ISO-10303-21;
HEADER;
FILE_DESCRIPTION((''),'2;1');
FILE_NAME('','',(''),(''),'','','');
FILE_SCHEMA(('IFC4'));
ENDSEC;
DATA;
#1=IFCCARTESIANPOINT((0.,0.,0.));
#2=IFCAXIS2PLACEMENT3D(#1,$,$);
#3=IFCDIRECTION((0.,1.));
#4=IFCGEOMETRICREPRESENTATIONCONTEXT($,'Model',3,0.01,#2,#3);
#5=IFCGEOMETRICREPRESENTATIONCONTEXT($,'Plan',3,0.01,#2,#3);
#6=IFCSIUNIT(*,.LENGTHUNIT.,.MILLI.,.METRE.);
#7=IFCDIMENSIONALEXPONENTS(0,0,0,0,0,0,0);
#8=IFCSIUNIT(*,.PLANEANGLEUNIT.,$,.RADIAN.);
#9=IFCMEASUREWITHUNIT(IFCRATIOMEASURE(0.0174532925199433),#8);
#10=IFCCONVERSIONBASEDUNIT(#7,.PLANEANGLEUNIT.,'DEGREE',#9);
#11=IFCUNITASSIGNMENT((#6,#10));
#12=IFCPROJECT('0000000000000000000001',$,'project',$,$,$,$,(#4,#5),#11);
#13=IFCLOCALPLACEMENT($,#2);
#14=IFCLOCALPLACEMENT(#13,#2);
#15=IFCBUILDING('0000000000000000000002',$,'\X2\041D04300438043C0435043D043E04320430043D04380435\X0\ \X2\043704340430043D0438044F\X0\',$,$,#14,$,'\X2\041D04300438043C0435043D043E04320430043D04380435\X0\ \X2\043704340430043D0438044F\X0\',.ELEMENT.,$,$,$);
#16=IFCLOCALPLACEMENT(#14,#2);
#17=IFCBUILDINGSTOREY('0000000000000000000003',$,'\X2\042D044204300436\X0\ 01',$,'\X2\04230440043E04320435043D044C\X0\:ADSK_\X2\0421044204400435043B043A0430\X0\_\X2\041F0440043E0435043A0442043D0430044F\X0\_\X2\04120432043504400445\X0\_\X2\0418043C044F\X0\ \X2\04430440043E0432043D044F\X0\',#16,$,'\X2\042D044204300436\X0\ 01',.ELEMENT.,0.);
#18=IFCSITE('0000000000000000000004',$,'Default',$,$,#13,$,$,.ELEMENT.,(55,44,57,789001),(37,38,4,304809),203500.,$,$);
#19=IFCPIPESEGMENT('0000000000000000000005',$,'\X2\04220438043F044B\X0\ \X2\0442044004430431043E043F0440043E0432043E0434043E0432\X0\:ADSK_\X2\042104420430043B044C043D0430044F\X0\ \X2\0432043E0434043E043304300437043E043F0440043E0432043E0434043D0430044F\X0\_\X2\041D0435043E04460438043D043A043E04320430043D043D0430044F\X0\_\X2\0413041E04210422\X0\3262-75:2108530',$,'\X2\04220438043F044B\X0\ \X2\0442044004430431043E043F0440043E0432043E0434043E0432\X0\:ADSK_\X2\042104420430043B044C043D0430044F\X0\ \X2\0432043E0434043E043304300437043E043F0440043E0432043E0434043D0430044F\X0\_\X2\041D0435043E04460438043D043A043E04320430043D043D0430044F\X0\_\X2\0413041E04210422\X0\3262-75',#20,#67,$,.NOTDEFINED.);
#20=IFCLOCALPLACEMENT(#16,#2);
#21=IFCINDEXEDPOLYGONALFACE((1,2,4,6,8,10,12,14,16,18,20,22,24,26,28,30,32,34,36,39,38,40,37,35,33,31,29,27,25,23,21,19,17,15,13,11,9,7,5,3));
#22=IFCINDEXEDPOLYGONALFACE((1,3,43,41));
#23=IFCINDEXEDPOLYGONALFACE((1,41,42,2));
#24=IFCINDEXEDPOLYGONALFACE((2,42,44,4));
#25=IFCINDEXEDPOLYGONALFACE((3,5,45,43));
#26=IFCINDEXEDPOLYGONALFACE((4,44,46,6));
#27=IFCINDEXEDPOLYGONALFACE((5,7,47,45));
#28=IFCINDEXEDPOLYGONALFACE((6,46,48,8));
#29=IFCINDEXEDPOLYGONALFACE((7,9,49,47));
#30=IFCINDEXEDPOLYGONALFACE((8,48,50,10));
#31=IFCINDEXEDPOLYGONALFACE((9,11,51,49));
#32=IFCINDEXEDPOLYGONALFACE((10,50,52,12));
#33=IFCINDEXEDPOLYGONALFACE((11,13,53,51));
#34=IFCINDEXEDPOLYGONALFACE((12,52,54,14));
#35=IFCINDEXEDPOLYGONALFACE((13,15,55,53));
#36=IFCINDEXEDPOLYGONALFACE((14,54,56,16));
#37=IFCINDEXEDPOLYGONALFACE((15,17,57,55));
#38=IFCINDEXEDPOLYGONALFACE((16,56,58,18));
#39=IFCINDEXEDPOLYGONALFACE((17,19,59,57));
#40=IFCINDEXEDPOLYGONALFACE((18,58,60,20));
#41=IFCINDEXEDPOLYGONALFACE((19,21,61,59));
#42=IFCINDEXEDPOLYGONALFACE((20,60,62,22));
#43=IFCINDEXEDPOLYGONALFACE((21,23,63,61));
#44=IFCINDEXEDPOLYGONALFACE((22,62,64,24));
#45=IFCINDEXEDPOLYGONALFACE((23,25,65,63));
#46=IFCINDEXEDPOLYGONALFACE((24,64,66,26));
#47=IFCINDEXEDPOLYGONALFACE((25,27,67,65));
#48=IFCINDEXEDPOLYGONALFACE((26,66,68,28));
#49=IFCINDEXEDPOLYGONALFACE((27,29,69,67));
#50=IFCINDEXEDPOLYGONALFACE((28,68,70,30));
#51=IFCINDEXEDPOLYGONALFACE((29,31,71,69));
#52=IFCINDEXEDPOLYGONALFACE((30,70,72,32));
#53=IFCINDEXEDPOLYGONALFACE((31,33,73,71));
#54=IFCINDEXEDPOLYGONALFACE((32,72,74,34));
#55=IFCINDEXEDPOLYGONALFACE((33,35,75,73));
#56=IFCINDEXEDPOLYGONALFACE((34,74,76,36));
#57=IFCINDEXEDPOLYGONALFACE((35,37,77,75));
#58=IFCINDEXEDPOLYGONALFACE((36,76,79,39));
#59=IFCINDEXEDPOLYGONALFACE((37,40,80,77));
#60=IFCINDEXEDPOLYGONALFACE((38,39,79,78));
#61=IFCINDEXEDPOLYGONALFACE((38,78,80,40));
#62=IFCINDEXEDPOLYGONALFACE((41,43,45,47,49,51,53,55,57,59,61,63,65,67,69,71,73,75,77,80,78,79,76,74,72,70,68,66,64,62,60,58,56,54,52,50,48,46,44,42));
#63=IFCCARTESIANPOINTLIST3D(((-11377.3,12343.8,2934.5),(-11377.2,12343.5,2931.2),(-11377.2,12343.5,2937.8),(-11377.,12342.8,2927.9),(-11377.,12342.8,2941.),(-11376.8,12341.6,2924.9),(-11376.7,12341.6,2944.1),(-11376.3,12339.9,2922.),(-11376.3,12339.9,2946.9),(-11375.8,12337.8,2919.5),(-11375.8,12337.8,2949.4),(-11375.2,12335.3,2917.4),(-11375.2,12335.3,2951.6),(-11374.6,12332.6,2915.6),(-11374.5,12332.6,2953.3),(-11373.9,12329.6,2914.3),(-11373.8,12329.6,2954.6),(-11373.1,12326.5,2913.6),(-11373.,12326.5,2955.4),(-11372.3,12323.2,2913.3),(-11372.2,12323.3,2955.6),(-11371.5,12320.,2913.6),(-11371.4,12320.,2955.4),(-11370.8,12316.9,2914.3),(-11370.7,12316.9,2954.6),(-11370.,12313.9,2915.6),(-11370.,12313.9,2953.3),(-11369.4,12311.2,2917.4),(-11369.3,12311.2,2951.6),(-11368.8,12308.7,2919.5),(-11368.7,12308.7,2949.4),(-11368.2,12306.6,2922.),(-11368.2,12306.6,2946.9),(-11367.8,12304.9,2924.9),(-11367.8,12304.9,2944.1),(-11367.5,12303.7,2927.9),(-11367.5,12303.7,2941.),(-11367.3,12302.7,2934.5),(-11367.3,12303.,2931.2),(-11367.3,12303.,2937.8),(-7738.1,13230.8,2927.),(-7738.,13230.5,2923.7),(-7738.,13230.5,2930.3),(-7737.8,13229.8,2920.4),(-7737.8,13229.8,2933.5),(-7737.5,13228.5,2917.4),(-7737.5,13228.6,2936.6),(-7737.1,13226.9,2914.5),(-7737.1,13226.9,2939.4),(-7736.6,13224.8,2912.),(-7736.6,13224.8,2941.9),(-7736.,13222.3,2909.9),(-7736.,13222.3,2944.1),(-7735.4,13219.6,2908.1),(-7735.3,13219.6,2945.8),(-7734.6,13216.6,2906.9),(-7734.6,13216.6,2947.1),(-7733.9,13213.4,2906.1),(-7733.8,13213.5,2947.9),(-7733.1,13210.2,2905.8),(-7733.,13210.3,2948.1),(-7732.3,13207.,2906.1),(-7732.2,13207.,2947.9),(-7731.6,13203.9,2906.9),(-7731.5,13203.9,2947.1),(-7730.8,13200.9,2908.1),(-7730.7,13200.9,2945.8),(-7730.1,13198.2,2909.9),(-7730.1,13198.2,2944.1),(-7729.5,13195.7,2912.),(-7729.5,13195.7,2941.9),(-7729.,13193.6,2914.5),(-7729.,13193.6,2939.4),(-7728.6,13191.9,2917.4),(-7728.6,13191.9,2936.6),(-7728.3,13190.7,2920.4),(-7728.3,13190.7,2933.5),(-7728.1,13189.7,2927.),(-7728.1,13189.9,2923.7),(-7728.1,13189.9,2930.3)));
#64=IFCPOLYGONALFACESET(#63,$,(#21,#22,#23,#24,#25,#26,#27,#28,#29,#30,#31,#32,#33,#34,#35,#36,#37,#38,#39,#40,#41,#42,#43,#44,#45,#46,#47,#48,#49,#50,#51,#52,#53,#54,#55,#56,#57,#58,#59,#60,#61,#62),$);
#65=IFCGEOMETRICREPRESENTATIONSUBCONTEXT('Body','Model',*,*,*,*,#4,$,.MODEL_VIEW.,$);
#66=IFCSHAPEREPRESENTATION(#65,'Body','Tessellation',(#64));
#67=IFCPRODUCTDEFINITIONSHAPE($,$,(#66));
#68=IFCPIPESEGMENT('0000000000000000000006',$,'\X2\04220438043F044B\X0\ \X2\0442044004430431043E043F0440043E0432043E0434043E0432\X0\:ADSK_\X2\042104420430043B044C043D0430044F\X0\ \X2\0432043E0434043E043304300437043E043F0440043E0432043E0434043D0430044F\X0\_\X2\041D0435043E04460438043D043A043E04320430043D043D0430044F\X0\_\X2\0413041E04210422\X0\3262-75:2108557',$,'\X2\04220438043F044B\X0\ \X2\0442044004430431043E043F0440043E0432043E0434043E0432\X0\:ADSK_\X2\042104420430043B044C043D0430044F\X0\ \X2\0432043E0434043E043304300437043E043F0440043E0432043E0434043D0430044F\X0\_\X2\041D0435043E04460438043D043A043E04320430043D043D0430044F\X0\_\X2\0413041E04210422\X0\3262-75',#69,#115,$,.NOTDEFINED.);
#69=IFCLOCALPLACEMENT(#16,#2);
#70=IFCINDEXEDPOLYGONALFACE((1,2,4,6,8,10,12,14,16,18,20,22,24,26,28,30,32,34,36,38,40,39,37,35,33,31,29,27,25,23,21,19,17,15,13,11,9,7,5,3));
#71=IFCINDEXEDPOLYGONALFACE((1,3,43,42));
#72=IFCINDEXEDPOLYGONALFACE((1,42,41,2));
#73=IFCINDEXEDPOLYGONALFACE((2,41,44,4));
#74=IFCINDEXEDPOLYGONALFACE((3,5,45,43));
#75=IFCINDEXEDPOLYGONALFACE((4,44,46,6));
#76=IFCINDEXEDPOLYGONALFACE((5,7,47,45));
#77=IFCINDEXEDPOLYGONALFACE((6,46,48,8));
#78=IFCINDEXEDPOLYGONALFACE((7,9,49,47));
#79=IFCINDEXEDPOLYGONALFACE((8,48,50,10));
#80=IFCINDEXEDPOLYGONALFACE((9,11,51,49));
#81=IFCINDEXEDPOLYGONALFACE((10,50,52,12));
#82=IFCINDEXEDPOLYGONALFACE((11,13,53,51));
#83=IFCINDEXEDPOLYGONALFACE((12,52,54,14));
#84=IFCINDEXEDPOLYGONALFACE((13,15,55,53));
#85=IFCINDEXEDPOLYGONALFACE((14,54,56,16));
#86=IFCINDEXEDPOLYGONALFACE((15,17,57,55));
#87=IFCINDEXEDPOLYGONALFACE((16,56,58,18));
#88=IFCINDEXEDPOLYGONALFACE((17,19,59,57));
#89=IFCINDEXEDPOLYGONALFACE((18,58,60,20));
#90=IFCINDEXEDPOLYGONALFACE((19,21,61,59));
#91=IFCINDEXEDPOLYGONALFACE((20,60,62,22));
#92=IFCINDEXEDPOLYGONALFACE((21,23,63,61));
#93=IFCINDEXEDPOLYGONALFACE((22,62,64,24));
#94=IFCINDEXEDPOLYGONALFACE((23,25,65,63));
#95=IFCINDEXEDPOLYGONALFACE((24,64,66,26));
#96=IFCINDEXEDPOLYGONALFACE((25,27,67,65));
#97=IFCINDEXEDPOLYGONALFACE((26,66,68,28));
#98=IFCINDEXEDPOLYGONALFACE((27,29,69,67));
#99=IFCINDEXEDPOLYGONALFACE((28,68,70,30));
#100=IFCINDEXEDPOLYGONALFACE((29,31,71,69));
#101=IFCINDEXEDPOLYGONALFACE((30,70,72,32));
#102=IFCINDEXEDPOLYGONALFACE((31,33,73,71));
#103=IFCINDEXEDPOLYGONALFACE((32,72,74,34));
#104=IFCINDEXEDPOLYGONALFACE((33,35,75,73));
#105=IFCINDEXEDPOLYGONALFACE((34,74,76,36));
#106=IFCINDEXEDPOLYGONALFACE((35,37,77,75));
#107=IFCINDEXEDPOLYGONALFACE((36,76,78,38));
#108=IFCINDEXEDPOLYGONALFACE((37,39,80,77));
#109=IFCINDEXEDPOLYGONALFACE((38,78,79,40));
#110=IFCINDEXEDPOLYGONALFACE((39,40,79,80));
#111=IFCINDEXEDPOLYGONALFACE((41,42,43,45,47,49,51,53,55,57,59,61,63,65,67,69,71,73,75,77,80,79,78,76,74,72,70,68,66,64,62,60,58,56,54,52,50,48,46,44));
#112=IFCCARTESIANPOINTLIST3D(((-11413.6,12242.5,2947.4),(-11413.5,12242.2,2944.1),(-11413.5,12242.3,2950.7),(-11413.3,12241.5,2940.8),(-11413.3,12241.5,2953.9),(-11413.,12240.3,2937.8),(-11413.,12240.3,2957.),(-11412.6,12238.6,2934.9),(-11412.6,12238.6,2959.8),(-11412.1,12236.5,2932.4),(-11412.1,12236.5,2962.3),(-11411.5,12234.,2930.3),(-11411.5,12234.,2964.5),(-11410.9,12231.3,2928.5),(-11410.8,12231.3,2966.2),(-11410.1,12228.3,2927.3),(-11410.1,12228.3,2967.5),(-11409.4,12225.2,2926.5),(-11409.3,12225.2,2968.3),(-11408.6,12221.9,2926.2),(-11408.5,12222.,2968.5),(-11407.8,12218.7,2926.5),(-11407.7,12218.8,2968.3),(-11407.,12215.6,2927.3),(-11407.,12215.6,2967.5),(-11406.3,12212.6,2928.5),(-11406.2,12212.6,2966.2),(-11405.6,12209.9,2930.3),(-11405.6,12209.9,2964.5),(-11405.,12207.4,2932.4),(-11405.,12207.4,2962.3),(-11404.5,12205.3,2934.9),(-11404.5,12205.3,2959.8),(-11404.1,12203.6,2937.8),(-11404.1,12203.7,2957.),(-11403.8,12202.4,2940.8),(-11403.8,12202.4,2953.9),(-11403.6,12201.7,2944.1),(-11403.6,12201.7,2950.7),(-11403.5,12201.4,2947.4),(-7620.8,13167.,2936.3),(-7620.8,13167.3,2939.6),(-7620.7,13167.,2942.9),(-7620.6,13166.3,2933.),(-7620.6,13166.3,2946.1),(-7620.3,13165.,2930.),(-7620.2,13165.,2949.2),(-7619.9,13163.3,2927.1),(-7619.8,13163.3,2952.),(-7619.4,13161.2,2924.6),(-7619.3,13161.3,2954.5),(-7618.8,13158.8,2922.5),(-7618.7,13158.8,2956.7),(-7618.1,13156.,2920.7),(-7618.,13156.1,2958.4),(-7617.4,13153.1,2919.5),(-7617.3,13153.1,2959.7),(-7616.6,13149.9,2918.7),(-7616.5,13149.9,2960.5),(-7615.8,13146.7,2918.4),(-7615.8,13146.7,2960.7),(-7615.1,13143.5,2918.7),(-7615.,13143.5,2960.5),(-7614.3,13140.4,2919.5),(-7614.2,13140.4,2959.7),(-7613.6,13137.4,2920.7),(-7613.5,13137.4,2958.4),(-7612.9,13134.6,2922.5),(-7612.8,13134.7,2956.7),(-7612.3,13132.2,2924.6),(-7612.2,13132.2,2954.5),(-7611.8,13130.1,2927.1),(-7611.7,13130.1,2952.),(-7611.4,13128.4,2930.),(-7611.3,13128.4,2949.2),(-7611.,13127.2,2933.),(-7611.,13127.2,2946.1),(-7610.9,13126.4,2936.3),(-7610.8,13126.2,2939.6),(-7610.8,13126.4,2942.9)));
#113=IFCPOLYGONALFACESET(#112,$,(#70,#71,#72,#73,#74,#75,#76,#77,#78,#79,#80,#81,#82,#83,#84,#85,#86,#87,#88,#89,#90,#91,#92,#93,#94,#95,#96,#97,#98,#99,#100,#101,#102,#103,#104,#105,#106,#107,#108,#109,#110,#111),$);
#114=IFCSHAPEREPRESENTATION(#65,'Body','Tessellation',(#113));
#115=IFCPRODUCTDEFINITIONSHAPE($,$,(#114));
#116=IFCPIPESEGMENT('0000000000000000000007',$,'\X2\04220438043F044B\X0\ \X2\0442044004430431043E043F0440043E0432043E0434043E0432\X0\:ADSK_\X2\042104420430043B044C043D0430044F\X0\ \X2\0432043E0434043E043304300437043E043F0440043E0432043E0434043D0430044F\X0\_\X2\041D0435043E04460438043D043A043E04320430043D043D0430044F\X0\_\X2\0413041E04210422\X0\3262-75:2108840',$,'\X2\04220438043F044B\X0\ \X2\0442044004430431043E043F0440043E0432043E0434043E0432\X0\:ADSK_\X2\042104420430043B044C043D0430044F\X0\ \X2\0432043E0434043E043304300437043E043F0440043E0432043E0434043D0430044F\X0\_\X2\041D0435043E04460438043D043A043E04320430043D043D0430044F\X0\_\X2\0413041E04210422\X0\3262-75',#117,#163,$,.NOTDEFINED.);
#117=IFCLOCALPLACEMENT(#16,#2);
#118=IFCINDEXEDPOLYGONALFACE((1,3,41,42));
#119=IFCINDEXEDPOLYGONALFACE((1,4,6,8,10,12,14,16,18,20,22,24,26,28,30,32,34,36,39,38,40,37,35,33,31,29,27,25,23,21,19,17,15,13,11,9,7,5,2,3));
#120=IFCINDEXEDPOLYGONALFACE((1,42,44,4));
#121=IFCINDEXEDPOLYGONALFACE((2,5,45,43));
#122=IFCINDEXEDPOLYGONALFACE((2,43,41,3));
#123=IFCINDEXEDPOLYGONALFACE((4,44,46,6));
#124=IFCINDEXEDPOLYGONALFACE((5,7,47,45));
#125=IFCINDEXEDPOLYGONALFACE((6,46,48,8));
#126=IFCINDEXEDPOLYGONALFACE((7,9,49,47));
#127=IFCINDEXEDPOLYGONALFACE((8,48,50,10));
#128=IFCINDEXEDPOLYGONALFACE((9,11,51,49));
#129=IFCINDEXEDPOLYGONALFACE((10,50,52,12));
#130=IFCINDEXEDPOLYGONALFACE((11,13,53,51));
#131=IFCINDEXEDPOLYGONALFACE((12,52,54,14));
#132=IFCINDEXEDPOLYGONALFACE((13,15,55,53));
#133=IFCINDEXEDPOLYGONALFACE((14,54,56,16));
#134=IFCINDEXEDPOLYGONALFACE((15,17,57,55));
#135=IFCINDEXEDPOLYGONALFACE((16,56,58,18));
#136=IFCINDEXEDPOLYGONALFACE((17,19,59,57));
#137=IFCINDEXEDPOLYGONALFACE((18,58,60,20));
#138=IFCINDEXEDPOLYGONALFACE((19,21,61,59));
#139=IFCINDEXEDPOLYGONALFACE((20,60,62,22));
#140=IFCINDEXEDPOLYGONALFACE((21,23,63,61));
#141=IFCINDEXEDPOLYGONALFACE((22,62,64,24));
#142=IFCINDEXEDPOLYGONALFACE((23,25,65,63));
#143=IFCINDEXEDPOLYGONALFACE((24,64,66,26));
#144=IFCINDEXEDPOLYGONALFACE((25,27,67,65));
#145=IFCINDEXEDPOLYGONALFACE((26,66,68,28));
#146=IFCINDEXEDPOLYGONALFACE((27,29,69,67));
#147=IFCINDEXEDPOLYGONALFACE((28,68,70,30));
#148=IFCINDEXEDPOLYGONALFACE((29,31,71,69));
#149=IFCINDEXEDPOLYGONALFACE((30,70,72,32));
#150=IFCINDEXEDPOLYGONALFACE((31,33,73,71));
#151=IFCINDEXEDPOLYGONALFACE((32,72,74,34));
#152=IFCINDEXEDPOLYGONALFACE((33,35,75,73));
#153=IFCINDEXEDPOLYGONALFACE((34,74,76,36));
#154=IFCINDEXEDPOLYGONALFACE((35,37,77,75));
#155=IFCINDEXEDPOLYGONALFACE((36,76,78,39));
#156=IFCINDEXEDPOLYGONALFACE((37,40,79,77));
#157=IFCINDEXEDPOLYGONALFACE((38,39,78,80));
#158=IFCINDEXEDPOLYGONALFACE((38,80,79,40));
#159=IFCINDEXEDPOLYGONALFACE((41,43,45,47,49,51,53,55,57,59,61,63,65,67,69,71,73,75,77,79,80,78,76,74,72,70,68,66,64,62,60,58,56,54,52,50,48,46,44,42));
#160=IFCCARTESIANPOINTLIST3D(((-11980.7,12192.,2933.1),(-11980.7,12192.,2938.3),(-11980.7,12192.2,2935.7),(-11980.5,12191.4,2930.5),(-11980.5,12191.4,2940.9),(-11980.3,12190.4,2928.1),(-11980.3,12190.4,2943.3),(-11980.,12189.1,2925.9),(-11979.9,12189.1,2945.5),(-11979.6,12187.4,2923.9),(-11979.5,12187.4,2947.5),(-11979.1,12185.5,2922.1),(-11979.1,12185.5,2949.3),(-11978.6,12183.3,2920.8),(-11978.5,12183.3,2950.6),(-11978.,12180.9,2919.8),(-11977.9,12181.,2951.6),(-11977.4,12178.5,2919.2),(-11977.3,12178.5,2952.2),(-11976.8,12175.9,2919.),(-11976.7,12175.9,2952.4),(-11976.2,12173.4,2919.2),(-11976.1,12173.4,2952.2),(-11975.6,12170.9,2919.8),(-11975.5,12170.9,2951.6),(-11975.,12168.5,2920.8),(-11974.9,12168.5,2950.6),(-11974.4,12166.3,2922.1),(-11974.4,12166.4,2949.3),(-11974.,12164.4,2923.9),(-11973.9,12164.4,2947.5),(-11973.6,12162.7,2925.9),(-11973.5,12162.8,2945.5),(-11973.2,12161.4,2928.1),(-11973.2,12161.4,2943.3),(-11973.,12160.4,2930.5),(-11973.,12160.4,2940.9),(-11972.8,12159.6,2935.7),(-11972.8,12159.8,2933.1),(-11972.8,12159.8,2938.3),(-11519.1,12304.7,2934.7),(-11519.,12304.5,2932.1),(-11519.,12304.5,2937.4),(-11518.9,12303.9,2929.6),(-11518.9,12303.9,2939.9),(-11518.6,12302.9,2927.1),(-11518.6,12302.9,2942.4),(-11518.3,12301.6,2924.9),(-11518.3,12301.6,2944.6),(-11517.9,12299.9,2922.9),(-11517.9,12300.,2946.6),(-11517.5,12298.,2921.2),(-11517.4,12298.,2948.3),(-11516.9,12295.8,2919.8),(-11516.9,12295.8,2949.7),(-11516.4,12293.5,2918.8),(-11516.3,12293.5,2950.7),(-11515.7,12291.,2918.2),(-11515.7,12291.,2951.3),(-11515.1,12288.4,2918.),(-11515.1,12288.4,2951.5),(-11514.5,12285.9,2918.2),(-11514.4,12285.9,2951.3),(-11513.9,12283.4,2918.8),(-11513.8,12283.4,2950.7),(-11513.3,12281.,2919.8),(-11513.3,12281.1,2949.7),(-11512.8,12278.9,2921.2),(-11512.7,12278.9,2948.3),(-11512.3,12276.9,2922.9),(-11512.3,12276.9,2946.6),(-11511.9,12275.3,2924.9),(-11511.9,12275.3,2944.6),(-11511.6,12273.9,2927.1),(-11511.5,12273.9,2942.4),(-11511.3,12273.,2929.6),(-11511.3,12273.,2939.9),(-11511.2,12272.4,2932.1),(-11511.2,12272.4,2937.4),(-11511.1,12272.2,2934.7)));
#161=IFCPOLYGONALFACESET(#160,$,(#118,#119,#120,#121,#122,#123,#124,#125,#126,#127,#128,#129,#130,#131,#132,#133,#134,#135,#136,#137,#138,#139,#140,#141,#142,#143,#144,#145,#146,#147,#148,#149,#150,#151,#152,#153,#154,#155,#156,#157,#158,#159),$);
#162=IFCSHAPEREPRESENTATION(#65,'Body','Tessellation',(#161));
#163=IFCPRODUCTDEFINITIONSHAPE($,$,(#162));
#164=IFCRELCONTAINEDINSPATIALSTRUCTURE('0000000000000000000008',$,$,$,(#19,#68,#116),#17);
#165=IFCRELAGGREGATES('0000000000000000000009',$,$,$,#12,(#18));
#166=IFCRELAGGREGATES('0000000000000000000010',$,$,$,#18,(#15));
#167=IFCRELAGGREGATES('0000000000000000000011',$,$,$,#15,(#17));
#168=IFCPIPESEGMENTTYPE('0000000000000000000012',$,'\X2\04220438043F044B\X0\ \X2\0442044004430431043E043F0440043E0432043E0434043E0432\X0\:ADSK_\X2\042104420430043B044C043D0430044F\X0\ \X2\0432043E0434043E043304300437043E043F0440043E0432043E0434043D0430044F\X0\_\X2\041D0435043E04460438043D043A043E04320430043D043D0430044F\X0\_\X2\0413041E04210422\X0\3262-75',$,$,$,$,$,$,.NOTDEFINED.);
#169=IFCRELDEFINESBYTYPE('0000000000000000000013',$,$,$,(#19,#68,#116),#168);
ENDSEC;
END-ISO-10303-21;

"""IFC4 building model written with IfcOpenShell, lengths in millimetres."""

from ifc_helpers import new_model, entity, si_unit, converted_unit, direction, frame, origin, place, context, subcontext, project, spatial, indexed_curve, outline, extrude, type_object, element, save


model = new_model("IFC4")

# Units and contexts
model_context = context("Model", 3, precision=0.01, world=origin(), true_north=direction((0.0, 1.0)))
plan_context = context("Plan", 3, precision=0.01, world=origin(), true_north=direction((0.0, 1.0)))
body_context = subcontext(model_context, "Body", "Model", "MODEL_VIEW")
ifc_project = project(units=[si_unit("LENGTHUNIT", "METRE", prefix="MILLI"), converted_unit("PLANEANGLEUNIT", "DEGREE", entity("IfcRatioMeasure", 0.0174532925199433), si_unit("PLANEANGLEUNIT", "RADIAN"), dimensions=[0, 0, 0, 0, 0, 0, 0])], contexts=[model_context, plan_context])

# Site, building, storey
site_placement = place(None, origin())
site = spatial("IfcSite", under=ifc_project, at=site_placement, Name="Default", CompositionType="ELEMENT", RefLatitude=(55, 44, 57, 789001), RefLongitude=(37, 38, 4, 304809), RefElevation=203500.0)
building_placement = place(site_placement, origin())
building = spatial("IfcBuilding", under=site, at=building_placement, Name="Наименование здания", LongName="Наименование здания", CompositionType="ELEMENT")
storey_placement = place(building_placement, origin())
storey = spatial("IfcBuildingStorey", under=building, at=storey_placement, Name="Этаж 01", ObjectType="Уровень:ADSK_Стрелка_Проектная_Вверх_Имя уровня", LongName="Этаж 01", CompositionType="ELEMENT", Elevation=0.0)

# Pipe segments
pipe_segment_type = type_object("IfcPipeSegmentType", Name="Типы трубопроводов:ADSK_Стальная водогазопроводная_Неоцинкованная_ГОСТ3262-75", PredefinedType="NOTDEFINED")
placement = place(storey_placement, origin())
element("IfcPipeSegment", 1, at=placement, inside=storey, type_object=pipe_segment_type, Name="Типы трубопроводов:ADSK_Стальная водогазопроводная_Неоцинкованная_ГОСТ3262-75:2108530", ObjectType="Типы трубопроводов:ADSK_Стальная водогазопроводная_Неоцинкованная_ГОСТ3262-75", PredefinedType="NOTDEFINED", context=body_context, shape_type="SweptSolid", body=[
    extrude(outline(indexed_curve([(21.1, 0.0), (20.9, 3.3), (20.1, 6.5), (18.8, 9.6), (17.1, 12.4), (15.0, 15.0), (12.4, 17.1), (9.6, 18.8), (6.5, 20.1), (3.3, 20.9), (0.0, 21.2), (-3.3, 20.9), (-6.5, 20.1), (-9.6, 18.8), (-12.4, 17.1), (-15.0, 15.0), (-17.1, 12.4), (-18.8, 9.6), (-20.1, 6.5), (-20.9, 3.3), (-21.2, 0.0), (-20.9, -3.3), (-20.1, -6.5), (-18.8, -9.6), (-17.1, -12.4), (-15.0, -15.0), (-12.4, -17.1), (-9.6, -18.8), (-6.5, -20.1), (-3.3, -20.9), (0.0, -21.1), (3.3, -20.9), (6.5, -20.1), (9.6, -18.8), (12.4, -17.1), (15.0, -15.0), (17.1, -12.4), (18.8, -9.6), (20.1, -6.5), (20.9, -3.3), (21.1, 0.0)], self_intersect=False)), frame((-7733.1, 13210.2, 2927.0), z_axis=(-0.971557, -0.236799, 0.002), x_axis=(0.236799, -0.971559, 0.0)), (0.0, 0.0, 1.0), 3745.8),
])
element("IfcPipeSegment", 2, at=placement, inside=storey, type_object=pipe_segment_type, Name="Типы трубопроводов:ADSK_Стальная водогазопроводная_Неоцинкованная_ГОСТ3262-75:2108557", ObjectType="Типы трубопроводов:ADSK_Стальная водогазопроводная_Неоцинкованная_ГОСТ3262-75", PredefinedType="NOTDEFINED", context=body_context, shape_type="SweptSolid", body=[
    extrude(outline(indexed_curve([(21.1, 0.0), (20.9, 3.3), (20.1, 6.5), (18.8, 9.6), (17.1, 12.4), (15.0, 15.0), (12.4, 17.1), (9.6, 18.8), (6.5, 20.1), (3.3, 20.9), (0.0, 21.1), (-3.3, 20.9), (-6.5, 20.1), (-9.6, 18.8), (-12.4, 17.1), (-15.0, 15.0), (-17.1, 12.4), (-18.8, 9.6), (-20.1, 6.5), (-20.9, 3.3), (-21.1, 0.0), (-20.9, -3.3), (-20.1, -6.5), (-18.8, -9.6), (-17.1, -12.4), (-15.0, -15.0), (-12.4, -17.1), (-9.6, -18.8), (-6.5, -20.1), (-3.3, -20.9), (0.0, -21.1), (3.3, -20.9), (6.5, -20.1), (9.6, -18.8), (12.4, -17.1), (15.0, -15.0), (17.1, -12.4), (18.8, -9.6), (20.1, -6.5), (20.9, -3.3), (21.1, 0.0)], self_intersect=False)), frame((-7615.8, 13146.7, 2939.6), z_axis=(-0.971536, -0.236883, 0.002), x_axis=(0.236884, -0.971538, 0.0)), (0.0, 0.0, 1.0), 3903.9),
])
element("IfcPipeSegment", 3, at=placement, inside=storey, type_object=pipe_segment_type, Name="Типы трубопроводов:ADSK_Стальная водогазопроводная_Неоцинкованная_ГОСТ3262-75:2108840", ObjectType="Типы трубопроводов:ADSK_Стальная водогазопроводная_Неоцинкованная_ГОСТ3262-75", PredefinedType="NOTDEFINED", context=body_context, shape_type="SweptSolid", body=[
    extrude(outline(indexed_curve([(16.8, 0.0), (16.5, 2.6), (15.9, 5.2), (14.9, 7.6), (13.6, 9.8), (11.8, 11.8), (9.8, 13.6), (7.6, 14.9), (5.2, 15.9), (2.6, 16.5), (0.0, 16.7), (-2.6, 16.5), (-5.2, 15.9), (-7.6, 14.9), (-9.8, 13.6), (-11.8, 11.8), (-13.6, 9.8), (-14.9, 7.6), (-15.9, 5.2), (-16.5, 2.6), (-16.8, 0.0), (-16.5, -2.6), (-15.9, -5.2), (-14.9, -7.6), (-13.6, -9.8), (-11.8, -11.8), (-9.8, -13.6), (-7.6, -14.9), (-5.2, -15.9), (-2.6, -16.5), (0.0, -16.7), (2.6, -16.5), (5.2, -15.9), (7.6, -14.9), (9.8, -13.6), (11.8, -11.8), (13.6, -9.8), (14.9, -7.6), (15.9, -5.2), (16.5, -2.6), (16.8, 0.0)], self_intersect=False)), frame((-11976.8, 12175.9, 2935.7), z_axis=(0.971557, 0.236799, -0.002), x_axis=(0.236799, -0.971559, 0.0)), (0.0, 0.0, 1.0), 475.2),
])

save(model, "model.ifc")
